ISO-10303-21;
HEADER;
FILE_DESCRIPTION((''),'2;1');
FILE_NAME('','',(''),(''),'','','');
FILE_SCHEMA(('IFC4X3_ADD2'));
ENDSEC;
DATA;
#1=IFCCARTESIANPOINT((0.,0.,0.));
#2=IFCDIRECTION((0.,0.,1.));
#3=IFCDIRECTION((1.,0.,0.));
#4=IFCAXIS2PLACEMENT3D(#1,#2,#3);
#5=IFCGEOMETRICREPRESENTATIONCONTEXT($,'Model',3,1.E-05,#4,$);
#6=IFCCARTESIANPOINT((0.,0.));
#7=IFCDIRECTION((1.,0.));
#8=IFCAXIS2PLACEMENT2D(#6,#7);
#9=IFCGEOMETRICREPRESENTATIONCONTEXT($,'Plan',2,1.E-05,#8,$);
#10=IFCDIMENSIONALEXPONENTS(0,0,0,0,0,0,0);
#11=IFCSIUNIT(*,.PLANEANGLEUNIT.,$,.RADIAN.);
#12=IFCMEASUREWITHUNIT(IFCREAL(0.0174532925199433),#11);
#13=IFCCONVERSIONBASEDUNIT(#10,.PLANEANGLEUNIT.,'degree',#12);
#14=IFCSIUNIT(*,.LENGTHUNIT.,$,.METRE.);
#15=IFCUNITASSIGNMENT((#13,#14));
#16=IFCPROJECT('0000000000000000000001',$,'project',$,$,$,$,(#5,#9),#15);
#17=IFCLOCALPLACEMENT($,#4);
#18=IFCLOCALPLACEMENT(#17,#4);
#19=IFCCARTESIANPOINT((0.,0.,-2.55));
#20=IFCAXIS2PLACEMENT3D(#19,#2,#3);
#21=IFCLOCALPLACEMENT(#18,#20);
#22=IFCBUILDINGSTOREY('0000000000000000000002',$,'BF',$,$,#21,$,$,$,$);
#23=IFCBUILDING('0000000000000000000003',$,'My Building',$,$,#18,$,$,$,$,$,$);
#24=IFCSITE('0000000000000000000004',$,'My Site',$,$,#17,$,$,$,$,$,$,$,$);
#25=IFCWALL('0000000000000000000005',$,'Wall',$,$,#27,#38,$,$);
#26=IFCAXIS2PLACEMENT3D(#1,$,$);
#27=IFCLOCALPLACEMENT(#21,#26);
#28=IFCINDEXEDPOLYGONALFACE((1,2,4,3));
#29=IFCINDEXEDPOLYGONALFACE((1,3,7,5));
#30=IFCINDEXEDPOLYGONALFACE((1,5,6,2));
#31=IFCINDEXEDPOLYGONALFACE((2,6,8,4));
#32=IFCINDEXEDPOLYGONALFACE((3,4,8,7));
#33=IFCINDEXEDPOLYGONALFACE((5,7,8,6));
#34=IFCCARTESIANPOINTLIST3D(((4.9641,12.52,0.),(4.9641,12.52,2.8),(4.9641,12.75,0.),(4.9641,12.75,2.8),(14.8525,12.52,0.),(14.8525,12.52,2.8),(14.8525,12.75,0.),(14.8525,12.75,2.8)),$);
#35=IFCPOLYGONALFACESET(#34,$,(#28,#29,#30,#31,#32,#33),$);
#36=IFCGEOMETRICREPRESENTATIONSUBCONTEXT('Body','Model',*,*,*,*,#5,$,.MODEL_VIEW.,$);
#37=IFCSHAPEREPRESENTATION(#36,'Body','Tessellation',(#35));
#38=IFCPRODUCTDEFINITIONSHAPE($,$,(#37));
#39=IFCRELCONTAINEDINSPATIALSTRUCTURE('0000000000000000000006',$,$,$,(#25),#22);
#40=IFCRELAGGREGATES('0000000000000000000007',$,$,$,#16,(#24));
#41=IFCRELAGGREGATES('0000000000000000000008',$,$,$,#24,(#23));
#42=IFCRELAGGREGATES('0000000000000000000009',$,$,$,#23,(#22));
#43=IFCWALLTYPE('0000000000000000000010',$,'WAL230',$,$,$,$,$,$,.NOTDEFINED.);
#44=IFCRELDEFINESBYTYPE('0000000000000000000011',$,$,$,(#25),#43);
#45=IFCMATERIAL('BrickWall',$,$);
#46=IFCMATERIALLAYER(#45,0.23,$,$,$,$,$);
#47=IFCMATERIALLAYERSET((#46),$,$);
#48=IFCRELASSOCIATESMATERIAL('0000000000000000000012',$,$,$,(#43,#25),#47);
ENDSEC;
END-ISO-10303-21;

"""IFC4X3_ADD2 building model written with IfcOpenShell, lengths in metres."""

from ifc_helpers import new_model, entity, si_unit, converted_unit, frame, origin_with_axes, origin_2d_with_axis, place, context, subcontext, project, spatial, indexed_curve, outline, extrude, material, layer, layer_set, layer_usage, type_object, element, save


model = new_model("IFC4X3_ADD2")

# Units and contexts
model_context = context("Model", 3, precision=1e-05, world=origin_with_axes())
plan_context = context("Plan", 2, precision=1e-05, world=origin_2d_with_axis())
body_context_1 = subcontext(model_context, "Body", "Model", "MODEL_VIEW")
ifc_project = project(units=[converted_unit("PLANEANGLEUNIT", "degree", entity("IfcReal", 0.0174532925199433), si_unit("PLANEANGLEUNIT", "RADIAN"), dimensions=[0, 0, 0, 0, 0, 0, 0]), si_unit("LENGTHUNIT", "METRE")], contexts=[model_context, plan_context])

# Site, building, storey
site_placement = place(None, origin_with_axes())
site = spatial("IfcSite", under=ifc_project, at=site_placement, Name="My Site")
building_placement = place(site_placement, origin_with_axes())
building = spatial("IfcBuilding", under=site, at=building_placement, Name="My Building")
storey_placement = place(building_placement, frame((0.0, 0.0, -2.55), z_axis=(0.0, 0.0, 1.0), x_axis=(1.0, 0.0, 0.0)))
storey = spatial("IfcBuildingStorey", under=building, at=storey_placement, Name="BF")

# Shared definitions
ifc_material_1 = material(Name="BrickWall")

# Shared definitions
ifc_layer_1 = layer(ifc_material_1, 0.23)
ifc_layer_set_1 = layer_set([ifc_layer_1])
wall_type = type_object("IfcWallType", Name="WAL230", PredefinedType="NOTDEFINED", material=ifc_layer_set_1)

# Wall
ifc_layer_usage_1 = layer_usage(ifc_layer_set_1, "AXIS2", "POSITIVE", 0.0)
wall_1_placement = place(storey_placement, frame((4.9641, 12.52, 0.0), z_axis=(0.0, 0.0, 1.0), x_axis=(1.0, 0.0, 0.0)))
element("IfcWall", 1, at=wall_1_placement, inside=storey, type_object=wall_type, material=ifc_layer_usage_1, Name="Wall", context=body_context_1, shape_type="SweptSolid", body=[
    extrude(outline(indexed_curve([(0.0, 0.0), (0.0, 0.23), (9.8884, 0.23), (9.8884, 0.0), (0.0, 0.0)], self_intersect=False)), origin_with_axes(), (0.0, 0.0, 1.0), 2.8),
])

save(model, "model.ifc")
